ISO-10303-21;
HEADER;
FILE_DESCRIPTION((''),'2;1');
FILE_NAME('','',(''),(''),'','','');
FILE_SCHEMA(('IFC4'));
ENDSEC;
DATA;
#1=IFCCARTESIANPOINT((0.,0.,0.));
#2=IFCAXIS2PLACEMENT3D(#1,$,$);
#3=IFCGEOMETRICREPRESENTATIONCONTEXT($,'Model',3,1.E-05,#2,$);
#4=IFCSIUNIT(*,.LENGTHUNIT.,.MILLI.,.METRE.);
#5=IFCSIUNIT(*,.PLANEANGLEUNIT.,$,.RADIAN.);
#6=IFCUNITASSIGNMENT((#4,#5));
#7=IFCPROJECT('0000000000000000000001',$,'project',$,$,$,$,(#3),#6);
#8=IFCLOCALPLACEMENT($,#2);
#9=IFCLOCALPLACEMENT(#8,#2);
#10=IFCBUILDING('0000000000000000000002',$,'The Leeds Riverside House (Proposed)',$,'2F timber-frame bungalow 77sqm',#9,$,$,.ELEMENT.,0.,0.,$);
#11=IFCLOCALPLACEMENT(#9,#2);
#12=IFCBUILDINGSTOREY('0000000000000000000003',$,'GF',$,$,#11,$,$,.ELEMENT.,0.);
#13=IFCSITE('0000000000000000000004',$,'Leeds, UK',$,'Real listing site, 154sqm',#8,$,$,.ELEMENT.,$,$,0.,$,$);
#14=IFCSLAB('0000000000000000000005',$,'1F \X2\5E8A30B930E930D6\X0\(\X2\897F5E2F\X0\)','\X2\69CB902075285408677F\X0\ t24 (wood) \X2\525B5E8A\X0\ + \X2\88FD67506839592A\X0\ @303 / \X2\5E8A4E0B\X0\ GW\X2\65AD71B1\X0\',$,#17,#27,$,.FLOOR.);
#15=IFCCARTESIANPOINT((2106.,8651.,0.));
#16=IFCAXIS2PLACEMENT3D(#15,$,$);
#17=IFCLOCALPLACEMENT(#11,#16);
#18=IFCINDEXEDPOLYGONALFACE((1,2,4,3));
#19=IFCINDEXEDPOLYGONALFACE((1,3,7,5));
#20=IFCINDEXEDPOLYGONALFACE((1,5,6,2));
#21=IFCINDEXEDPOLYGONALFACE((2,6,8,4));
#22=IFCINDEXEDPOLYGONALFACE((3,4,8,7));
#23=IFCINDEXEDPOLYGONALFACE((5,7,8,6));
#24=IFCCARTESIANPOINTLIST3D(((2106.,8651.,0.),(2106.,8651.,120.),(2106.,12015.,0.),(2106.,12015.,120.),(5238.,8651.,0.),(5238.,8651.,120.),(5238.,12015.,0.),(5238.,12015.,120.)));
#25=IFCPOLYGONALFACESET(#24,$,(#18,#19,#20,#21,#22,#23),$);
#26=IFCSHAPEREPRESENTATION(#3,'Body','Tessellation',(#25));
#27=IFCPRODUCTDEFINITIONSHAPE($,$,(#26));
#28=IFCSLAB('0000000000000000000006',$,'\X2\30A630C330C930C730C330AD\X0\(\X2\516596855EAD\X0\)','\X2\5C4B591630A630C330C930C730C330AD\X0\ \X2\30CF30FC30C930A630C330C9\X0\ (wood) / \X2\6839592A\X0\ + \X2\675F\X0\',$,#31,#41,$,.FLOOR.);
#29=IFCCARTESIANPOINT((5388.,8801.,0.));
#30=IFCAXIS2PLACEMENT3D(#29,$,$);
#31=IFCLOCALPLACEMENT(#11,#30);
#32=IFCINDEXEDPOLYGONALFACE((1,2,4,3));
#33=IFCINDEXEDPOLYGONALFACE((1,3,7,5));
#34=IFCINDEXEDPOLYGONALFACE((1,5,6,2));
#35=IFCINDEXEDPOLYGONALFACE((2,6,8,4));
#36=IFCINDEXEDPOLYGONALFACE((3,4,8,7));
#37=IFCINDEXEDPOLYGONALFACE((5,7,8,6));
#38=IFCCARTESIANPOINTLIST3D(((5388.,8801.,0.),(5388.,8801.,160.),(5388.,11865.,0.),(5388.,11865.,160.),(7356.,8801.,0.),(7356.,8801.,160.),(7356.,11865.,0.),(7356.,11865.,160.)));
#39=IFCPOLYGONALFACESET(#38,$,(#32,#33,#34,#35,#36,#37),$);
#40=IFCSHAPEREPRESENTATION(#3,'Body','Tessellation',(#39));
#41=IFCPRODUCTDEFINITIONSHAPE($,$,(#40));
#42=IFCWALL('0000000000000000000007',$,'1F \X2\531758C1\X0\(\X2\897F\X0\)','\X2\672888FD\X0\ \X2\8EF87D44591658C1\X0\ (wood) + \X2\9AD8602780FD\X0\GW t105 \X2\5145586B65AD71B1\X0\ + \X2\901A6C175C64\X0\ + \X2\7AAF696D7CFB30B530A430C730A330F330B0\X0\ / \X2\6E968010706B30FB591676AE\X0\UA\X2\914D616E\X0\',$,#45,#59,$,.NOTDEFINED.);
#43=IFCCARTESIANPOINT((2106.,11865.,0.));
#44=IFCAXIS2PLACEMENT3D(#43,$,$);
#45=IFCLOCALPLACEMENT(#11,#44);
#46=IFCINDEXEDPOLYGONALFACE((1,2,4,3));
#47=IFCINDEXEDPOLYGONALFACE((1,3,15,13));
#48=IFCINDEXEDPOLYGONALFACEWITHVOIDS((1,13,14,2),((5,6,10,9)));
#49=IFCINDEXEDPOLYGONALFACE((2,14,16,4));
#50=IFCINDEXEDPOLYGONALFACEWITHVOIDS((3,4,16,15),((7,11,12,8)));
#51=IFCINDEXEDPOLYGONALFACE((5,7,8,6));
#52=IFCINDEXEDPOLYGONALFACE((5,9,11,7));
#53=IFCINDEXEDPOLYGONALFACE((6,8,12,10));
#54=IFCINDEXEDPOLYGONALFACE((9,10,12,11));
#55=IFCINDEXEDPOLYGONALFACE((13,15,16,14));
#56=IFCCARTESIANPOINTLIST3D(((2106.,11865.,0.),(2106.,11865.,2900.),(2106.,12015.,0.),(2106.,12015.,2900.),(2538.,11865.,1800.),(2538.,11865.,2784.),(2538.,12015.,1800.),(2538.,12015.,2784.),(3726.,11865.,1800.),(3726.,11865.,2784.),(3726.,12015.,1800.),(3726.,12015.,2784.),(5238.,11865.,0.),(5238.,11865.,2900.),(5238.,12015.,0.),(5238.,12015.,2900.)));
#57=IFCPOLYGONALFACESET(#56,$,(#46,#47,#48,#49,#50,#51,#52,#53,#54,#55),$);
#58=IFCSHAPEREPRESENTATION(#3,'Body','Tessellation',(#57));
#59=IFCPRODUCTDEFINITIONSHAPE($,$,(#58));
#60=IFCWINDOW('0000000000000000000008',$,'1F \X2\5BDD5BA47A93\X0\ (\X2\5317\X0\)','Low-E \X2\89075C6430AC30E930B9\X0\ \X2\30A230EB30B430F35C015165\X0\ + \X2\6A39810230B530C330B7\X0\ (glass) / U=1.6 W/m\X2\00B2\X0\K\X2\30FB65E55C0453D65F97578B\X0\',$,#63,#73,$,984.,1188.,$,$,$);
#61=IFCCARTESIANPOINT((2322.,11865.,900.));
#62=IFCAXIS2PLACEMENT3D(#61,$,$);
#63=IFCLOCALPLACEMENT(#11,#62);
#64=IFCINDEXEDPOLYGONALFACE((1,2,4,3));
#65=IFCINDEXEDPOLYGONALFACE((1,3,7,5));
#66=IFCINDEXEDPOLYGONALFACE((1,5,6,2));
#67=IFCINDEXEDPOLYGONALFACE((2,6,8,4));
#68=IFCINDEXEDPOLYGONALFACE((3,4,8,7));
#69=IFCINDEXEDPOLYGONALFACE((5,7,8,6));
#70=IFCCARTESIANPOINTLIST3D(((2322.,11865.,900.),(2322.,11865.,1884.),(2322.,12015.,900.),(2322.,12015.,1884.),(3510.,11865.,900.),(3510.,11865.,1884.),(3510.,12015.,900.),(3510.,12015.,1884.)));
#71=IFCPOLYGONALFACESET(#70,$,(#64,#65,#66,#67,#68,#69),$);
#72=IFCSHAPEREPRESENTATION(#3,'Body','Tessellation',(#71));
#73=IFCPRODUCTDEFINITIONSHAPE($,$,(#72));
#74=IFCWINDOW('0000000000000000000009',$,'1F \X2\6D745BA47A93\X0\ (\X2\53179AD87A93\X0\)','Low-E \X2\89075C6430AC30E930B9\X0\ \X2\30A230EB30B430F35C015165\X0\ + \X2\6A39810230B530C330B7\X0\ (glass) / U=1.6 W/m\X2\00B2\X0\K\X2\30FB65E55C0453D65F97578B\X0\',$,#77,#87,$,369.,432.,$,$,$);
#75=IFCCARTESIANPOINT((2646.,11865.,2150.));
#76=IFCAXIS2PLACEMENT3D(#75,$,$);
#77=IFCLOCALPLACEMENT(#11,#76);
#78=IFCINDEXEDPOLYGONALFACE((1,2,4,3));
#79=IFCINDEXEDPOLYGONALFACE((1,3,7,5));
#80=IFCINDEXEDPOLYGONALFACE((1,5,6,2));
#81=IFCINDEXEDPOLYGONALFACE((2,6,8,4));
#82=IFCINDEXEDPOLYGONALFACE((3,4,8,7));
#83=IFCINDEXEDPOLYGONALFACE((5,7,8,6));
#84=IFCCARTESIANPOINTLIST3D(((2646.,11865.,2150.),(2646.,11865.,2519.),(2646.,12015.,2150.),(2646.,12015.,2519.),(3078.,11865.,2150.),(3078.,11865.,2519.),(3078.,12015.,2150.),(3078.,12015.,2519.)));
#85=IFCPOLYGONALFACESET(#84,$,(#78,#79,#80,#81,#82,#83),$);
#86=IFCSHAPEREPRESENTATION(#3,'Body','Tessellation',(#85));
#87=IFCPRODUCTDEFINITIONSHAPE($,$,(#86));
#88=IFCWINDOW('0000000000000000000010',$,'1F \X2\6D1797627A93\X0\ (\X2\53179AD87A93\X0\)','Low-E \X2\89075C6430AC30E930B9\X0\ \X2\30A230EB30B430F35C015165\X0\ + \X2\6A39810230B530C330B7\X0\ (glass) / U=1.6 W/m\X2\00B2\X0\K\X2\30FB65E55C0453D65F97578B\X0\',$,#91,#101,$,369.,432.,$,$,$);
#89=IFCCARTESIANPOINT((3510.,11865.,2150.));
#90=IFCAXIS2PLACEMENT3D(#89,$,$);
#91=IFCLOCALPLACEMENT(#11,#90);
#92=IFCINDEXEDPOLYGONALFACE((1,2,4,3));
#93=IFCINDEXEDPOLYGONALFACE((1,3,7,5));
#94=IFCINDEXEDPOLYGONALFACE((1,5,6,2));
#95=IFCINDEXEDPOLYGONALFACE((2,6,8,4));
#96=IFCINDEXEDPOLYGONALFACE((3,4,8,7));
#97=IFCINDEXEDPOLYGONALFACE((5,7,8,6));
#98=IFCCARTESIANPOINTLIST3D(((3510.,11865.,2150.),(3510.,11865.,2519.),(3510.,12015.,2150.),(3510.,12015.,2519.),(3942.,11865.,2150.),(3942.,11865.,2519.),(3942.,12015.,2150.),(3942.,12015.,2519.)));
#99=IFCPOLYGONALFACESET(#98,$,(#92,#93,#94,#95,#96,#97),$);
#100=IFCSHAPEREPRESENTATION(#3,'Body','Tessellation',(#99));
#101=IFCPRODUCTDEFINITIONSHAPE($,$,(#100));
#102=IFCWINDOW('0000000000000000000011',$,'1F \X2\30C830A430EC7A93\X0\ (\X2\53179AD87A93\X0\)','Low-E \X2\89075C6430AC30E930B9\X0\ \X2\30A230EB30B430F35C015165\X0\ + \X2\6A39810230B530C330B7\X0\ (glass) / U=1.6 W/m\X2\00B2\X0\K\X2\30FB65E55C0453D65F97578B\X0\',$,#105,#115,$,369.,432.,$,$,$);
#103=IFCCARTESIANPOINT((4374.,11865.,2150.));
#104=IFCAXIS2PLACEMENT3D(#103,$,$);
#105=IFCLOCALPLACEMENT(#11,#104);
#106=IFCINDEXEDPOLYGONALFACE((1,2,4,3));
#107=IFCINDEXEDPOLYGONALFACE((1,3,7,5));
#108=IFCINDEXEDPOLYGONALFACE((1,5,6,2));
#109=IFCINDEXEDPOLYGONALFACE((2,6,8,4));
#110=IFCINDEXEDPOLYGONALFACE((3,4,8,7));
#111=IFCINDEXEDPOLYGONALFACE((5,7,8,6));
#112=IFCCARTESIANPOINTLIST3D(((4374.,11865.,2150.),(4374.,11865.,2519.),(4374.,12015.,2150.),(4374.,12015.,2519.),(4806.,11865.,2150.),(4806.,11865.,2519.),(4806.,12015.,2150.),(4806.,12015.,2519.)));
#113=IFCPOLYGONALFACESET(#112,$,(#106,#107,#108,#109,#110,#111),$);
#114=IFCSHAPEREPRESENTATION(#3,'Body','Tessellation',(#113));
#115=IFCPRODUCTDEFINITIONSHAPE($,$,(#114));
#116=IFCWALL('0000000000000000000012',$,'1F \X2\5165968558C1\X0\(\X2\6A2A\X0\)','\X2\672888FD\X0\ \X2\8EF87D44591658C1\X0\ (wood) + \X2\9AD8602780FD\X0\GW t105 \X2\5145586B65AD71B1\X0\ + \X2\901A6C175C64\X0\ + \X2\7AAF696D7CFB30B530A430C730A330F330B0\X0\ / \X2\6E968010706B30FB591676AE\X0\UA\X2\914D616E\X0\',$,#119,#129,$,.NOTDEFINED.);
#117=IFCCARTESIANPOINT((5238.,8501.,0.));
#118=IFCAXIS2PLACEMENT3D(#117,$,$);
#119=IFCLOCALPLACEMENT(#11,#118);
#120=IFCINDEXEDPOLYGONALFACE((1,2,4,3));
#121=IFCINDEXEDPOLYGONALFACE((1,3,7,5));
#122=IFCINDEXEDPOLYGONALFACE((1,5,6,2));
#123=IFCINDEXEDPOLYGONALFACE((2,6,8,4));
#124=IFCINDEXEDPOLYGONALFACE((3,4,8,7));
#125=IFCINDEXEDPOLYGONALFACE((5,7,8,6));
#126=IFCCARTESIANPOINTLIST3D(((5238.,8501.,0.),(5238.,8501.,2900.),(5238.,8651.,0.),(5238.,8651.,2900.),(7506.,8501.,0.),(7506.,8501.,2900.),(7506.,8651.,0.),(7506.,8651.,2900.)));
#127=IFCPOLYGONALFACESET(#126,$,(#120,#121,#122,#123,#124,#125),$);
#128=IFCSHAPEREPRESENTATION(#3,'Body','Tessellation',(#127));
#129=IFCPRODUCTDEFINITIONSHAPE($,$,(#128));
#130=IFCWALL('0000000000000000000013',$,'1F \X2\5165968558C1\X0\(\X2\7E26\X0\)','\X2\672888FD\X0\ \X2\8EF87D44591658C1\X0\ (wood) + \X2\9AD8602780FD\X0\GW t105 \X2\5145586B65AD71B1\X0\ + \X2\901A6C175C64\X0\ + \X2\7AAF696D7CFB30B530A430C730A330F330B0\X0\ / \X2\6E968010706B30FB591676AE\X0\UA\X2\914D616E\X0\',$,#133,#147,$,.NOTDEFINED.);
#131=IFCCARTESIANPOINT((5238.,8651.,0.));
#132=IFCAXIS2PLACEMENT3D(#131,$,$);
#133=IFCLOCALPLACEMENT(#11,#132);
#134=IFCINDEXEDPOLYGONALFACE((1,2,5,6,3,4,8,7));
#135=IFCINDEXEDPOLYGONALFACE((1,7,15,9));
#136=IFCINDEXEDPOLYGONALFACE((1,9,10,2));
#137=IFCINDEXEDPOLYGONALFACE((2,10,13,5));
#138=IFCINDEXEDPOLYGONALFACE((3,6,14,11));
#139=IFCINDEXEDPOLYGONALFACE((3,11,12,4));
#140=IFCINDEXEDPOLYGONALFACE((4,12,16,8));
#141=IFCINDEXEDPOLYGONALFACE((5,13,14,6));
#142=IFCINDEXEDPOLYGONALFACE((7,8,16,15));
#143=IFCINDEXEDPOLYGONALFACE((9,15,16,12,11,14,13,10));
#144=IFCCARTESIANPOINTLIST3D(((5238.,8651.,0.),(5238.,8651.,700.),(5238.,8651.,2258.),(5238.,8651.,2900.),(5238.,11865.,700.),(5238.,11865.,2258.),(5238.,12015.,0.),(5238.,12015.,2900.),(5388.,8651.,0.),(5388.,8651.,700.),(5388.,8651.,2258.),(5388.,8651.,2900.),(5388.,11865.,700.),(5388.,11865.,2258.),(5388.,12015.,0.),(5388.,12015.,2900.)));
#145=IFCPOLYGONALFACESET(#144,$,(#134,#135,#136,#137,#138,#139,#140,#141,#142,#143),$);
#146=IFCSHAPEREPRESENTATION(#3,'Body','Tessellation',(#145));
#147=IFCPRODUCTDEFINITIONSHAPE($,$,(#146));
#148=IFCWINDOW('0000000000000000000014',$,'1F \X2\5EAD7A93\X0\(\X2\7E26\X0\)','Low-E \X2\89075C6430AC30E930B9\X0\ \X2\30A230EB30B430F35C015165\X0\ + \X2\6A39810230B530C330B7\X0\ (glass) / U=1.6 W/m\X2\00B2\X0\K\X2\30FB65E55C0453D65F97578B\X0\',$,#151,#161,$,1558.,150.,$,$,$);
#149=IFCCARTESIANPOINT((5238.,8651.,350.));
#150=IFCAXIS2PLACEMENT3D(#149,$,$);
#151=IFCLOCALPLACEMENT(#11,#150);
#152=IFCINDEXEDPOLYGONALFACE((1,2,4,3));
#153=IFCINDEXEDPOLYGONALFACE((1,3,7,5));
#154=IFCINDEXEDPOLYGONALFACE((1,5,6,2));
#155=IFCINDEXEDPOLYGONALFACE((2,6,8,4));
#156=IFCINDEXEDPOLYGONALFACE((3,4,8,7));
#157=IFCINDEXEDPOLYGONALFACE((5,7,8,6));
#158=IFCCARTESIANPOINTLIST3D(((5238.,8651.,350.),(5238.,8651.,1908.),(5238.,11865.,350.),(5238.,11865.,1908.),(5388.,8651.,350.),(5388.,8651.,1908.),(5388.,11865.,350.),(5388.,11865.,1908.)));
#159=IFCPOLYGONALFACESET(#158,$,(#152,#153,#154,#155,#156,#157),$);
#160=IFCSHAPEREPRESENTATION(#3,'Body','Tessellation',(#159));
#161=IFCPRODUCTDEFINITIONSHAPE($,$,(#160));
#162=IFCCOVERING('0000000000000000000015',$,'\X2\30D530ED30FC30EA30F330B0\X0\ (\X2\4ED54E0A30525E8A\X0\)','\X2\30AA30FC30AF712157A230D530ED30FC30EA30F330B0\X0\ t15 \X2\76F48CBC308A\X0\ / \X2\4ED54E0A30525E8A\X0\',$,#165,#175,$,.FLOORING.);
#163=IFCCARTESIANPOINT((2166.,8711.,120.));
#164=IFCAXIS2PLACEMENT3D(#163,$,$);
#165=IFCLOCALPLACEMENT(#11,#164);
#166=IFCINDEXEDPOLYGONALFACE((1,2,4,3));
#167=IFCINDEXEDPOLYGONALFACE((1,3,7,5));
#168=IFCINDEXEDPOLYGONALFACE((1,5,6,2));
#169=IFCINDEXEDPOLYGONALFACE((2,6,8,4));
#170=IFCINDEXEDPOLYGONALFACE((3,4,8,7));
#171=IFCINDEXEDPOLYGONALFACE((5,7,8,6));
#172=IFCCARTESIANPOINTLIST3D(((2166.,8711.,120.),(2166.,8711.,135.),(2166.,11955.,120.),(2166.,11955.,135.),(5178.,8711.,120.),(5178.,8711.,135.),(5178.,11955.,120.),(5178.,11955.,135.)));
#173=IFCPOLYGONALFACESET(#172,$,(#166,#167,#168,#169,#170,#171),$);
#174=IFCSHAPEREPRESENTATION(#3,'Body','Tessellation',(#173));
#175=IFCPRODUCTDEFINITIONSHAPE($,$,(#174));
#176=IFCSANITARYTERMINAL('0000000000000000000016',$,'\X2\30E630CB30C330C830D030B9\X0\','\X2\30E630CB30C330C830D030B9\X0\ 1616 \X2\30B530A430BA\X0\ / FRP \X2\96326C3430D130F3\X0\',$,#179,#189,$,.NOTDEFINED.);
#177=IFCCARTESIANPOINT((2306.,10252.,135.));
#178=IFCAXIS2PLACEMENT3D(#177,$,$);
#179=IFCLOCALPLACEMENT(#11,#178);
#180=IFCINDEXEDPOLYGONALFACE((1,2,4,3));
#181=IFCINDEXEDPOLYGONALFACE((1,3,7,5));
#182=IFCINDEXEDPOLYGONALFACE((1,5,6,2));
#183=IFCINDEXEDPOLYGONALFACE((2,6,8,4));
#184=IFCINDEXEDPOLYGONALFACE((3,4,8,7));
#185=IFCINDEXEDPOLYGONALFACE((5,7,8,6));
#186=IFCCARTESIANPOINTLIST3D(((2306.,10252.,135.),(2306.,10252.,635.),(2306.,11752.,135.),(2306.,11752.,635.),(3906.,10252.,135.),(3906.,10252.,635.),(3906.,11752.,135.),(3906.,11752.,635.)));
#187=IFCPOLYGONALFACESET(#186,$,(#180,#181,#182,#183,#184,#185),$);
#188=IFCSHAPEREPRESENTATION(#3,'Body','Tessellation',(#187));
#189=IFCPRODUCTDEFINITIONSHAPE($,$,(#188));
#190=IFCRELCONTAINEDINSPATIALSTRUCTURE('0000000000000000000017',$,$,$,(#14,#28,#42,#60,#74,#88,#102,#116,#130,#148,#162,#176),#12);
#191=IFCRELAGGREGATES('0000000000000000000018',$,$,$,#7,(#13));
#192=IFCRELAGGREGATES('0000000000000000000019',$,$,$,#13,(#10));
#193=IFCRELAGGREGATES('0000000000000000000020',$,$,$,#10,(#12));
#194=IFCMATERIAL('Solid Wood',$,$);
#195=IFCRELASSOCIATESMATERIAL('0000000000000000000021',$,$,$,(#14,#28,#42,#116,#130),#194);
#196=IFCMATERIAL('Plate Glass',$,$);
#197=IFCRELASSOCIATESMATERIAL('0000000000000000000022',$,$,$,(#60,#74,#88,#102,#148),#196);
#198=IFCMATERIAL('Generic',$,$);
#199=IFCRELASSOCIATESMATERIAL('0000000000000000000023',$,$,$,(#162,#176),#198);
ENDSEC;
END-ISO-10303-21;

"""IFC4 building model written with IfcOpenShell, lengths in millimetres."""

from ifc_helpers import new_model, si_unit, frame, frame_2d, origin, place, context, project, spatial, rectangle, extrude, material, element, fill, save


model = new_model("IFC4")

# Units and contexts
model_context = context("Model", 3, precision=1e-05, world=origin())
ifc_project = project(units=[si_unit("LENGTHUNIT", "METRE", prefix="MILLI"), si_unit("PLANEANGLEUNIT", "RADIAN")], contexts=[model_context])

# Site, building, storey
site_placement = place(None, origin())
site = spatial("IfcSite", under=ifc_project, at=site_placement, Name="Leeds, UK", ObjectType="Real listing site, 154sqm", CompositionType="ELEMENT", RefElevation=0.0)
building_placement = place(site_placement, origin())
building = spatial("IfcBuilding", under=site, at=building_placement, Name="The Leeds Riverside House (Proposed)", ObjectType="2F timber-frame bungalow 77sqm", CompositionType="ELEMENT", ElevationOfRefHeight=0.0, ElevationOfTerrain=0.0)
storey_placement = place(building_placement, origin())
storey = spatial("IfcBuildingStorey", under=building, at=storey_placement, Name="GF", CompositionType="ELEMENT", Elevation=0.0)

# Slabs
ifc_material_1 = material(Name="Solid Wood")
slab_1_placement = place(storey_placement, frame((2106.0, 8651.0, 0.0)))
element("IfcSlab", 1, at=slab_1_placement, inside=storey, material=ifc_material_1, Name="1F 床スラブ(西帯)", Description="構造用合板 t24 (wood) 剛床 + 製材根太 @303 / 床下 GW断熱", PredefinedType="FLOOR", context=model_context, shape_type="SweptSolid", body=[
    extrude(rectangle(XDim=3132.0, YDim=3364.0, at=frame_2d((1566.0, 1682.0))), frame((2106.0, 8651.0, 0.0)), (0.0, 0.0, 1.0), 120.0),
])
slab_2_placement = place(storey_placement, frame((5388.0, 8801.0, 0.0)))
element("IfcSlab", 2, at=slab_2_placement, inside=storey, material=ifc_material_1, Name="ウッドデッキ(入隅庭)", Description="屋外ウッドデッキ ハードウッド (wood) / 根太 + 束", PredefinedType="FLOOR", context=model_context, shape_type="SweptSolid", body=[
    extrude(rectangle(XDim=1968.0, YDim=3064.0, at=frame_2d((984.0, 1532.0))), frame((5388.0, 8801.0, 0.0)), (0.0, 0.0, 1.0), 160.0),
])

# Wall, openings, windows
wall_1_placement = place(storey_placement, frame((2106.0, 11865.0, 0.0)))
wall_1 = element("IfcWall", 3, at=wall_1_placement, inside=storey, material=ifc_material_1, Name="1F 北壁(西)", Description="木製 軸組外壁 (wood) + 高性能GW t105 充填断熱 + 通気層 + 窯業系サイディング / 準耐火・外皮UA配慮", PredefinedType="NOTDEFINED", context=model_context, shape_type="SweptSolid", body=[
    extrude(rectangle(XDim=3132.0, YDim=150.0, at=frame_2d((1566.0, 75.0))), frame((2106.0, 11865.0, 0.0)), (0.0, 0.0, 1.0), 2900.0),
])
opening_1_placement = place(storey_placement, frame((2322.0, 11865.0, 900.0)))
opening_1 = element("IfcOpeningElement", 4, at=opening_1_placement, cuts=wall_1, PredefinedType="NOTDEFINED", context=model_context, shape_type="SweptSolid", body=[
    extrude(rectangle(XDim=1188.0, YDim=150.0, at=frame_2d((594.0, 75.0))), frame((2322.0, 11865.0, 900.0)), (0.0, 0.0, 1.0), 984.0),
])
opening_2_placement = place(storey_placement, frame((2646.0, 11865.0, 2150.0)))
opening_2 = element("IfcOpeningElement", 5, at=opening_2_placement, cuts=wall_1, PredefinedType="NOTDEFINED", context=model_context, shape_type="SweptSolid", body=[
    extrude(rectangle(XDim=432.0, YDim=150.0, at=frame_2d((216.0, 75.0))), frame((2646.0, 11865.0, 2150.0)), (0.0, 0.0, 1.0), 369.0),
])
opening_3_placement = place(storey_placement, frame((3510.0, 11865.0, 2150.0)))
opening_3 = element("IfcOpeningElement", 6, at=opening_3_placement, cuts=wall_1, PredefinedType="NOTDEFINED", context=model_context, shape_type="SweptSolid", body=[
    extrude(rectangle(XDim=432.0, YDim=150.0, at=frame_2d((216.0, 75.0))), frame((3510.0, 11865.0, 2150.0)), (0.0, 0.0, 1.0), 369.0),
])
opening_4_placement = place(storey_placement, frame((4374.0, 11865.0, 2150.0)))
opening_4 = element("IfcOpeningElement", 7, at=opening_4_placement, cuts=wall_1, PredefinedType="NOTDEFINED", context=model_context, shape_type="SweptSolid", body=[
    extrude(rectangle(XDim=432.0, YDim=150.0, at=frame_2d((216.0, 75.0))), frame((4374.0, 11865.0, 2150.0)), (0.0, 0.0, 1.0), 369.0),
])
ifc_material_2 = material(Name="Plate Glass")
window_1_placement = place(storey_placement, frame((2322.0, 11865.0, 900.0)))
window_1 = element("IfcWindow", 8, at=window_1_placement, inside=storey, material=ifc_material_2, Name="1F 寝室窓 (北)", Description="Low-E 複層ガラス アルゴン封入 + 樹脂サッシ (glass) / U=1.6 W/m²K・日射取得型", OverallHeight=984.0, OverallWidth=1188.0, context=model_context, shape_type="SweptSolid", body=[
    extrude(rectangle(XDim=1188.0, YDim=150.0, at=frame_2d((594.0, 75.0))), frame((2322.0, 11865.0, 900.0)), (0.0, 0.0, 1.0), 984.0),
])
fill(opening_1, window_1)
window_2_placement = place(storey_placement, frame((2646.0, 11865.0, 2150.0)))
window_2 = element("IfcWindow", 9, at=window_2_placement, inside=storey, material=ifc_material_2, Name="1F 浴室窓 (北高窓)", Description="Low-E 複層ガラス アルゴン封入 + 樹脂サッシ (glass) / U=1.6 W/m²K・日射取得型", OverallHeight=369.0, OverallWidth=432.0, context=model_context, shape_type="SweptSolid", body=[
    extrude(rectangle(XDim=432.0, YDim=150.0, at=frame_2d((216.0, 75.0))), frame((2646.0, 11865.0, 2150.0)), (0.0, 0.0, 1.0), 369.0),
])
fill(opening_2, window_2)
window_3_placement = place(storey_placement, frame((3510.0, 11865.0, 2150.0)))
window_3 = element("IfcWindow", 10, at=window_3_placement, inside=storey, material=ifc_material_2, Name="1F 洗面窓 (北高窓)", Description="Low-E 複層ガラス アルゴン封入 + 樹脂サッシ (glass) / U=1.6 W/m²K・日射取得型", OverallHeight=369.0, OverallWidth=432.0, context=model_context, shape_type="SweptSolid", body=[
    extrude(rectangle(XDim=432.0, YDim=150.0, at=frame_2d((216.0, 75.0))), frame((3510.0, 11865.0, 2150.0)), (0.0, 0.0, 1.0), 369.0),
])
fill(opening_3, window_3)
window_4_placement = place(storey_placement, frame((4374.0, 11865.0, 2150.0)))
window_4 = element("IfcWindow", 11, at=window_4_placement, inside=storey, material=ifc_material_2, Name="1F トイレ窓 (北高窓)", Description="Low-E 複層ガラス アルゴン封入 + 樹脂サッシ (glass) / U=1.6 W/m²K・日射取得型", OverallHeight=369.0, OverallWidth=432.0, context=model_context, shape_type="SweptSolid", body=[
    extrude(rectangle(XDim=432.0, YDim=150.0, at=frame_2d((216.0, 75.0))), frame((4374.0, 11865.0, 2150.0)), (0.0, 0.0, 1.0), 369.0),
])
fill(opening_4, window_4)

# Wall
wall_2_placement = place(storey_placement, frame((5238.0, 8501.0, 0.0)))
element("IfcWall", 12, at=wall_2_placement, inside=storey, material=ifc_material_1, Name="1F 入隅壁(横)", Description="木製 軸組外壁 (wood) + 高性能GW t105 充填断熱 + 通気層 + 窯業系サイディング / 準耐火・外皮UA配慮", PredefinedType="NOTDEFINED", context=model_context, shape_type="SweptSolid", body=[
    extrude(rectangle(XDim=2268.0, YDim=150.0, at=frame_2d((1134.0, 75.0))), frame((5238.0, 8501.0, 0.0)), (0.0, 0.0, 1.0), 2900.0),
])

# Wall, opening, window
wall_3_placement = place(storey_placement, frame((5238.0, 8651.0, 0.0)))
wall_3 = element("IfcWall", 13, at=wall_3_placement, inside=storey, material=ifc_material_1, Name="1F 入隅壁(縦)", Description="木製 軸組外壁 (wood) + 高性能GW t105 充填断熱 + 通気層 + 窯業系サイディング / 準耐火・外皮UA配慮", PredefinedType="NOTDEFINED", context=model_context, shape_type="SweptSolid", body=[
    extrude(rectangle(XDim=150.0, YDim=3364.0, at=frame_2d((75.0, 1682.0))), frame((5238.0, 8651.0, 0.0)), (0.0, 0.0, 1.0), 2900.0),
])
opening_5_placement = place(storey_placement, frame((5238.0, 8651.0, 350.0)))
opening_5 = element("IfcOpeningElement", 14, at=opening_5_placement, cuts=wall_3, PredefinedType="NOTDEFINED", context=model_context, shape_type="SweptSolid", body=[
    extrude(rectangle(XDim=150.0, YDim=3214.0, at=frame_2d((75.0, 1607.0))), frame((5238.0, 8651.0, 350.0)), (0.0, 0.0, 1.0), 1558.0),
])
window_5_placement = place(storey_placement, frame((5238.0, 8651.0, 350.0)))
window_5 = element("IfcWindow", 15, at=window_5_placement, inside=storey, material=ifc_material_2, Name="1F 庭窓(縦)", Description="Low-E 複層ガラス アルゴン封入 + 樹脂サッシ (glass) / U=1.6 W/m²K・日射取得型", OverallHeight=1558.0, OverallWidth=150.0, context=model_context, shape_type="SweptSolid", body=[
    extrude(rectangle(XDim=150.0, YDim=3214.0, at=frame_2d((75.0, 1607.0))), frame((5238.0, 8651.0, 350.0)), (0.0, 0.0, 1.0), 1558.0),
])
fill(opening_5, window_5)

# Covering
ifc_material_3 = material(Name="Generic")
covering_placement = place(storey_placement, frame((2166.0, 8711.0, 120.0)))
element("IfcCovering", 16, at=covering_placement, inside=storey, material=ifc_material_3, Name="フローリング (仕上げ床)", Description="オーク無垢フローリング t15 直貼り / 仕上げ床", PredefinedType="FLOORING", context=model_context, shape_type="SweptSolid", body=[
    extrude(rectangle(XDim=3012.0, YDim=3244.0, at=frame_2d((1506.0, 1622.0))), frame((2166.0, 8711.0, 120.0)), (0.0, 0.0, 1.0), 15.0),
])

# Sanitary terminal
sanitary_terminal_1_placement = place(storey_placement, frame((2306.0, 10252.0, 135.0)))
element("IfcSanitaryTerminal", 17, at=sanitary_terminal_1_placement, inside=storey, material=ifc_material_3, Name="ユニットバス", Description="ユニットバス 1616 サイズ / FRP 防水パン", PredefinedType="NOTDEFINED", context=model_context, shape_type="SweptSolid", body=[
    extrude(rectangle(XDim=1600.0, YDim=1500.0, at=frame_2d((800.0, 750.0))), frame((2306.0, 10252.0, 135.0)), (0.0, 0.0, 1.0), 500.0),
])

save(model, "model.ifc")
